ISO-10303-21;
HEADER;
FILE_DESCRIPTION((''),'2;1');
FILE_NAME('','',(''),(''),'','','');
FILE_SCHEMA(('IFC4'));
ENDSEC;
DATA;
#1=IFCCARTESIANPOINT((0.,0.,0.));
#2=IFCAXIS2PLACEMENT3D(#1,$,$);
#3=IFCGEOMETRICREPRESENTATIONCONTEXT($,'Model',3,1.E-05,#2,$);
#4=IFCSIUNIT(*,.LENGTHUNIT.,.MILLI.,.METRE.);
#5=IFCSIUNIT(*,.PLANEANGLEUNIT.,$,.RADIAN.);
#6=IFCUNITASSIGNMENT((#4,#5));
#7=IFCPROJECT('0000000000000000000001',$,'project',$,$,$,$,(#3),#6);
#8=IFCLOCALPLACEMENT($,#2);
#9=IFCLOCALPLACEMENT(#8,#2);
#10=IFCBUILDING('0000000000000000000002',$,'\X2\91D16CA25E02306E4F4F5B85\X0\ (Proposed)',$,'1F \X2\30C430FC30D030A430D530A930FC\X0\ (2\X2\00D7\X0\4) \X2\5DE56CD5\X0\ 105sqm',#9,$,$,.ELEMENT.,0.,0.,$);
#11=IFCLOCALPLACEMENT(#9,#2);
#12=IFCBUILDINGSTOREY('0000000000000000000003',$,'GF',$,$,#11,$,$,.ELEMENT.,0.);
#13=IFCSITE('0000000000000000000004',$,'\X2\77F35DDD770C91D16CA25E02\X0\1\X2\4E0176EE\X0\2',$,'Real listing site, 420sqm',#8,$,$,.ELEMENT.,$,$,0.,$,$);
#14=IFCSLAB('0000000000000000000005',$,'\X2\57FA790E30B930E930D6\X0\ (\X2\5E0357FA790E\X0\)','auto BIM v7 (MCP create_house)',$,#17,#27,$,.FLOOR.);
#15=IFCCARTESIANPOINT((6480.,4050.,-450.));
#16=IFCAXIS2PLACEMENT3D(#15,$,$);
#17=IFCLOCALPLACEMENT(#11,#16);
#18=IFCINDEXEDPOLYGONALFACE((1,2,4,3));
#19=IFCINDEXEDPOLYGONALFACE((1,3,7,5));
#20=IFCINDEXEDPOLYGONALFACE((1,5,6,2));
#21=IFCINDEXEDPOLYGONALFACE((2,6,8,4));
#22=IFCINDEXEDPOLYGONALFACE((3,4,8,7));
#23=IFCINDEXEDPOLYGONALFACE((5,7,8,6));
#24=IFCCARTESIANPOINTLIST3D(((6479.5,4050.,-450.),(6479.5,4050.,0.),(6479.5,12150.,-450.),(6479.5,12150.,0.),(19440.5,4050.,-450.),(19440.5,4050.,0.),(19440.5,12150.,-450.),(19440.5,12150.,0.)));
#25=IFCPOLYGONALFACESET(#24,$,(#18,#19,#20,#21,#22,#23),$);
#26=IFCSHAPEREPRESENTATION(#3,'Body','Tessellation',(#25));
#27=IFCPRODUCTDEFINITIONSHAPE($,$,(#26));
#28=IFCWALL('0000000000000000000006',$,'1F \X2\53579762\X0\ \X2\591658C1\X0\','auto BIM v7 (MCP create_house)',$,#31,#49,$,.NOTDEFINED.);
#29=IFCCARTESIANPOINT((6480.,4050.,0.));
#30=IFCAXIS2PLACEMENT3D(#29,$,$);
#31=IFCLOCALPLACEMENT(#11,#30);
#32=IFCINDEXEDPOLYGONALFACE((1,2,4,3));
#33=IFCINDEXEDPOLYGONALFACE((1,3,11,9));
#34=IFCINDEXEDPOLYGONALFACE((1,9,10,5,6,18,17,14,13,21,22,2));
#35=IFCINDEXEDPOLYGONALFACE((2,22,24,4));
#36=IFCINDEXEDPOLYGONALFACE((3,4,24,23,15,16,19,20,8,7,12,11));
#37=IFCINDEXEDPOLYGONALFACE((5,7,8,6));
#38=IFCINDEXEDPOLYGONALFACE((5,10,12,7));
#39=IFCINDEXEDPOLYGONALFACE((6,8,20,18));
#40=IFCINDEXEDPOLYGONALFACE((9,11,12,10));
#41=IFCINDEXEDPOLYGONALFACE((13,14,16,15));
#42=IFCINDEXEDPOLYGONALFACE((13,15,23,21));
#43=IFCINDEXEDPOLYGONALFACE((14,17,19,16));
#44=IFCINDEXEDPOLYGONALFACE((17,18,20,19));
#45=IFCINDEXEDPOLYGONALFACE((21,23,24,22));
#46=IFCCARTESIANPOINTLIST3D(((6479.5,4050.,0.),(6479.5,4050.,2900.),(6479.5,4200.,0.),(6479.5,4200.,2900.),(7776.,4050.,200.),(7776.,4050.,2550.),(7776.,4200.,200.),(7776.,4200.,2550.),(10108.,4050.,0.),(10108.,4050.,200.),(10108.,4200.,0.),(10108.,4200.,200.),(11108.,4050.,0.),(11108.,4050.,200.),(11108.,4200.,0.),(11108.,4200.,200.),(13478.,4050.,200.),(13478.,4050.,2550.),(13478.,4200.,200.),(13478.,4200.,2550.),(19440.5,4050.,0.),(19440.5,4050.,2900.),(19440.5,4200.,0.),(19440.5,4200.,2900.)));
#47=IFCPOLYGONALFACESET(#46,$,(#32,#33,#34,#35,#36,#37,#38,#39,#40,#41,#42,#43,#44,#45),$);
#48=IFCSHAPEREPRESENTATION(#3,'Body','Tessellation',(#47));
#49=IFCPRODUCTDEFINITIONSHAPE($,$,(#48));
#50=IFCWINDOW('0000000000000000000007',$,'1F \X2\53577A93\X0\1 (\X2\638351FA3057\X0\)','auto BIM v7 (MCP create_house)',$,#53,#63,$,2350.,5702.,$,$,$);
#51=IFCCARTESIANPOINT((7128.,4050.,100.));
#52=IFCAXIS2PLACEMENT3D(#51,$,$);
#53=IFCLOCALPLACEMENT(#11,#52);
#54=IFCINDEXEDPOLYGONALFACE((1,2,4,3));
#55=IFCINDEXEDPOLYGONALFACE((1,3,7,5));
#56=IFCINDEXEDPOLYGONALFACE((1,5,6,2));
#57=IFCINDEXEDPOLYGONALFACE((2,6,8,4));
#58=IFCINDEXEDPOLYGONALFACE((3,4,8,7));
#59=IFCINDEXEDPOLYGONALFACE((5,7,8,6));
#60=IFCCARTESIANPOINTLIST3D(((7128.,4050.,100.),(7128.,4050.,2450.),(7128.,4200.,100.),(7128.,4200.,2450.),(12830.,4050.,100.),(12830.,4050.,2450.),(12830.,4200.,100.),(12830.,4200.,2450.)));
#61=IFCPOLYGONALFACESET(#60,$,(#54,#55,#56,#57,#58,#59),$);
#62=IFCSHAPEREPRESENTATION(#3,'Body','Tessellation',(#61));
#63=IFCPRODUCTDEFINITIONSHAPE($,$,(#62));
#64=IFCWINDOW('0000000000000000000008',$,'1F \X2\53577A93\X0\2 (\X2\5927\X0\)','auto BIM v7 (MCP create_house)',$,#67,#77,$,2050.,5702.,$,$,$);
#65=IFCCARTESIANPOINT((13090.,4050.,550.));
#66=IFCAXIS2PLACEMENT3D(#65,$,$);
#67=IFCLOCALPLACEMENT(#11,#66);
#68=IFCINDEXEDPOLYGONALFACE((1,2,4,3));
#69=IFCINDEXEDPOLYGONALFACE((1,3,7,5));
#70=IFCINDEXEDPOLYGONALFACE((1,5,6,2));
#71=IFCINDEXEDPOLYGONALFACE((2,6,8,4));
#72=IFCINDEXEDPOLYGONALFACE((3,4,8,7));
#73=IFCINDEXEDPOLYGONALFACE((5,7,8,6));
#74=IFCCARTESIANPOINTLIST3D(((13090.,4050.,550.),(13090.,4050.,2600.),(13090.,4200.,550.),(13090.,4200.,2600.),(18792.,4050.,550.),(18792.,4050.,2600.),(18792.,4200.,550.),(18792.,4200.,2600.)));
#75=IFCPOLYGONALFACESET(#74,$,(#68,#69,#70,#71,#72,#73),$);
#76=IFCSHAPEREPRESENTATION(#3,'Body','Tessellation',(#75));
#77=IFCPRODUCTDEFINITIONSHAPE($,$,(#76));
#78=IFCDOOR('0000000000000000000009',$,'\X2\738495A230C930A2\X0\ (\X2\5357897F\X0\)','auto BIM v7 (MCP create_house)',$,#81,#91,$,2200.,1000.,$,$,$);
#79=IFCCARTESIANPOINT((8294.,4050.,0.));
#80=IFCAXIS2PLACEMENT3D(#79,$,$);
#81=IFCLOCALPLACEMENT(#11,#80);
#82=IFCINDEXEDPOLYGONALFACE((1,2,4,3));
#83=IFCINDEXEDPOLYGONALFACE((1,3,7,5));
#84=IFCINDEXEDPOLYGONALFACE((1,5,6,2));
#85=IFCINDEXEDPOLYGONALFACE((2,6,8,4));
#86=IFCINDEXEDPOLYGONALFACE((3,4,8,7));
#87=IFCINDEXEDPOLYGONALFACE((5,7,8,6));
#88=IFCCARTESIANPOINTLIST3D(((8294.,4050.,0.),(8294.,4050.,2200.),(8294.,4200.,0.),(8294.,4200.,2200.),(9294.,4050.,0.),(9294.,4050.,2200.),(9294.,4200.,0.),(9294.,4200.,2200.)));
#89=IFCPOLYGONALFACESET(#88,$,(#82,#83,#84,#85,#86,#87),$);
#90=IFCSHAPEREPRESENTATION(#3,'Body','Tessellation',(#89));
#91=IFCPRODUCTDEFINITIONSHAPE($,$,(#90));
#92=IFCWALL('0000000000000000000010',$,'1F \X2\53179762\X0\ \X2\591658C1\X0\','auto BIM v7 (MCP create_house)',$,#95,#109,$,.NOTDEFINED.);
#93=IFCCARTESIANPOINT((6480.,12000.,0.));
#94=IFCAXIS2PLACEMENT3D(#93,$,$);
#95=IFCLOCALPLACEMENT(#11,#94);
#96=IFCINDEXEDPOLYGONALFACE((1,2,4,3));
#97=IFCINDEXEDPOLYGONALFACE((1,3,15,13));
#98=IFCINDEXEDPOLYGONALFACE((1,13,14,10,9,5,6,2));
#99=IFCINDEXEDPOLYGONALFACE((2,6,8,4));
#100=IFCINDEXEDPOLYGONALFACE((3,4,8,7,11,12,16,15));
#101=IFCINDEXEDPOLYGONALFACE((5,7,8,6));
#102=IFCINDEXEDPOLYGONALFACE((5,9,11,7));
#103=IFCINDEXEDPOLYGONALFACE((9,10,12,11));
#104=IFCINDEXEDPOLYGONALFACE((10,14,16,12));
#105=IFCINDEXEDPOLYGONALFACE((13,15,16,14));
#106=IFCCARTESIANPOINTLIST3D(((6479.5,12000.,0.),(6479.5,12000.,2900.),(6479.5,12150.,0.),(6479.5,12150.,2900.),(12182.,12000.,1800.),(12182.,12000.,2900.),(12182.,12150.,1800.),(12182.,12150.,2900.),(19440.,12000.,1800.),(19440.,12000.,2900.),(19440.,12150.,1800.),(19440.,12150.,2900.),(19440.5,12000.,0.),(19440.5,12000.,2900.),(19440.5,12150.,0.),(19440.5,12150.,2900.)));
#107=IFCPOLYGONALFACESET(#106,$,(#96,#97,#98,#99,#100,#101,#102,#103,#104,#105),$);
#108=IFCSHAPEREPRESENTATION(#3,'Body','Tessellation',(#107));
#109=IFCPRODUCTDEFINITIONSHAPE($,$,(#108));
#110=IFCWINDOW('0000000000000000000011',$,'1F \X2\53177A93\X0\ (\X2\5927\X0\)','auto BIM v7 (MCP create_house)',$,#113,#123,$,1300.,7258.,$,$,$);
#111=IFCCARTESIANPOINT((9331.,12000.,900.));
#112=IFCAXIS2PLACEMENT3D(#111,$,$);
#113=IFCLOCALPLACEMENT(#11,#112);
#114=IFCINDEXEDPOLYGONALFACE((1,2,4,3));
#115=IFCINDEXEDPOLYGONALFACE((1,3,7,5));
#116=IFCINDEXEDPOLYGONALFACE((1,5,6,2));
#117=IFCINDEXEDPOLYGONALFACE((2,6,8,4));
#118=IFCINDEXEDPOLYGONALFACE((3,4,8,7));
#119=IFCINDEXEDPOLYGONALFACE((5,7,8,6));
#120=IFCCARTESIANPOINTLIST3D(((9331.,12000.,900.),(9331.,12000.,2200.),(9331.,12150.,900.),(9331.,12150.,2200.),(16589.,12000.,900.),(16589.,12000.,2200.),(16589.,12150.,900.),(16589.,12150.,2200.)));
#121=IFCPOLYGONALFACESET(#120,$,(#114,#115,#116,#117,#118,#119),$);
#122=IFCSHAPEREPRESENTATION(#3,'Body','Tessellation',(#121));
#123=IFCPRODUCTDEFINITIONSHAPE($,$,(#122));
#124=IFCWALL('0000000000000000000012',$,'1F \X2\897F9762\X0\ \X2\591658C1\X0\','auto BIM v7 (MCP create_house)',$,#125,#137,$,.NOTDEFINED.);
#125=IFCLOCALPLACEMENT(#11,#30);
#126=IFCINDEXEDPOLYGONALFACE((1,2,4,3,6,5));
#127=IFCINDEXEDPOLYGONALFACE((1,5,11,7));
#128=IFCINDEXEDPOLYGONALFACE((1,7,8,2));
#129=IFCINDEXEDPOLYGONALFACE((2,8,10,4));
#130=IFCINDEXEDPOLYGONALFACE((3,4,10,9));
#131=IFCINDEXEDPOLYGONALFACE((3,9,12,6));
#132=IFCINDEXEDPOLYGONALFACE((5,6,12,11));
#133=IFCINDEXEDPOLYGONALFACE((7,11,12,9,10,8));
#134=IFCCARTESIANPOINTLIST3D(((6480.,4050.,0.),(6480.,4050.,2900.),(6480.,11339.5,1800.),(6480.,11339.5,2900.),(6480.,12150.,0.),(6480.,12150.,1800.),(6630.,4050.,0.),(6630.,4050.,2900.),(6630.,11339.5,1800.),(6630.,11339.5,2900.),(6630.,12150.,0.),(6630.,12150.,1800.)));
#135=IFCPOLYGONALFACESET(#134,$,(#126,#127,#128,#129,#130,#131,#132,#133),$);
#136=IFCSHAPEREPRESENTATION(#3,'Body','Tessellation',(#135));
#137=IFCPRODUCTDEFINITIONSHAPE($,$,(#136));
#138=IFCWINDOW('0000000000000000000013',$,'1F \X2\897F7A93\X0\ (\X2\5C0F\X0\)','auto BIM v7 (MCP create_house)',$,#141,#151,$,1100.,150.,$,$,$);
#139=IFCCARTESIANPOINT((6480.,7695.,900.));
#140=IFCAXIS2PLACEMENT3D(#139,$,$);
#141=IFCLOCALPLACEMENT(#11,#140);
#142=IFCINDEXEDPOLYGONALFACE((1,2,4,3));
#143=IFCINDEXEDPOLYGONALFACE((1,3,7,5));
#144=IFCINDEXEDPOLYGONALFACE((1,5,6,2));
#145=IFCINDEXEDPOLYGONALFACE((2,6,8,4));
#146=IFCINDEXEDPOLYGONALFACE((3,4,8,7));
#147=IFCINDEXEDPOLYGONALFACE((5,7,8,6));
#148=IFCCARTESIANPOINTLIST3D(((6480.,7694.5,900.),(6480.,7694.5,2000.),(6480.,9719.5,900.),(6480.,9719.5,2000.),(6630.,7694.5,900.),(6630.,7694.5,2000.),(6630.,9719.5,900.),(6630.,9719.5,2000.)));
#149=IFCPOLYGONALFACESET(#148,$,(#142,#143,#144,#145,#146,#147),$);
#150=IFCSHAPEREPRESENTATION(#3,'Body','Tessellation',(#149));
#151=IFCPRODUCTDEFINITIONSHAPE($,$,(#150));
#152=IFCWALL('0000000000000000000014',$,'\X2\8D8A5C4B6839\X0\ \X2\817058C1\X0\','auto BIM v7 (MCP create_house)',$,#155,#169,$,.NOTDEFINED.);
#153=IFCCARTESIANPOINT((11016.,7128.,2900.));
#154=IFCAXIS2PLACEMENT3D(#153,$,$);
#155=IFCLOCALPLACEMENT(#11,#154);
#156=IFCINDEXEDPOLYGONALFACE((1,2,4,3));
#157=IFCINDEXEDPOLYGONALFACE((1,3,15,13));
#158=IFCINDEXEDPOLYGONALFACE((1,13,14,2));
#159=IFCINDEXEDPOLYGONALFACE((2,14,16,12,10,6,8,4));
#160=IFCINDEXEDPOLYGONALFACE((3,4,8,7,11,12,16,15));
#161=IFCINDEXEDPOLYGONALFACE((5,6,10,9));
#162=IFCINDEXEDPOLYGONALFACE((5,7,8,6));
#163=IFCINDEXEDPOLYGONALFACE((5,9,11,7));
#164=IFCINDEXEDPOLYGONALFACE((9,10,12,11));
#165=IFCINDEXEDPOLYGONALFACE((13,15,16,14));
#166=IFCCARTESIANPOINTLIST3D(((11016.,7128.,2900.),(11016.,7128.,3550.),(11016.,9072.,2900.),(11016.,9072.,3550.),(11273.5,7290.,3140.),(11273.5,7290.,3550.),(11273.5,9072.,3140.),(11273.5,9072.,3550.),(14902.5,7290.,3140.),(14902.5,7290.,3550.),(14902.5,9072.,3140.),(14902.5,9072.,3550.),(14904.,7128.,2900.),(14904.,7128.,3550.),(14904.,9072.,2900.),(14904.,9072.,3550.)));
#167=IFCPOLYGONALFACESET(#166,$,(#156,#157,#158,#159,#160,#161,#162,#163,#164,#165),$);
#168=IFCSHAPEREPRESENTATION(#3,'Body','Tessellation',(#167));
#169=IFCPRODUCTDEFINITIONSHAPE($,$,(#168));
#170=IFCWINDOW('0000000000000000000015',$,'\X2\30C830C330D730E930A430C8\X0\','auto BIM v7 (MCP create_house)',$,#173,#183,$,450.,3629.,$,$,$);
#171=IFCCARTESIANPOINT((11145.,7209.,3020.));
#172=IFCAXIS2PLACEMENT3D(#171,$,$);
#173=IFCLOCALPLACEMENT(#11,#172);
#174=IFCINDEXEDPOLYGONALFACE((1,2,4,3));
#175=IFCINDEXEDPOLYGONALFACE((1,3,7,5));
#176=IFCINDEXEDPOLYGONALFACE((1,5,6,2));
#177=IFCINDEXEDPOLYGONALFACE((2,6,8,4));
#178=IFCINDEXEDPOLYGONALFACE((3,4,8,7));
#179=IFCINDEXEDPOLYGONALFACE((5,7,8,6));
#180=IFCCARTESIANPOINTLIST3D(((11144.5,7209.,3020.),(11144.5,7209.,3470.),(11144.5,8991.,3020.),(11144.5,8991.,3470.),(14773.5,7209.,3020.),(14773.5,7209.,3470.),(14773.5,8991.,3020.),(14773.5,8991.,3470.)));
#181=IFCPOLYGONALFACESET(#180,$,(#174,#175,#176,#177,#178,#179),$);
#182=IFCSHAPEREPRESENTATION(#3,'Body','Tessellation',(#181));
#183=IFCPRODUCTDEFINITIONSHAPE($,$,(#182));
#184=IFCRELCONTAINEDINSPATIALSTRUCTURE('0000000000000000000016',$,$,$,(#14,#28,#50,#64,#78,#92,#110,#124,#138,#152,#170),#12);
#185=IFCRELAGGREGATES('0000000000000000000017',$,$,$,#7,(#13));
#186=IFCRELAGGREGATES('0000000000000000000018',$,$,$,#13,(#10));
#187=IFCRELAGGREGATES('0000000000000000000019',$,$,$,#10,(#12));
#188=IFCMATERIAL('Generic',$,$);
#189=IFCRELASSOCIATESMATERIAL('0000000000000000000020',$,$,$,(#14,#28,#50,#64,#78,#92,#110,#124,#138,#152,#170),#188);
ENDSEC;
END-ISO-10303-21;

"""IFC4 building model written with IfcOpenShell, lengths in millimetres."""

from ifc_helpers import new_model, si_unit, frame, frame_2d, origin, place, context, project, spatial, rectangle, extrude, material, element, fill, save


model = new_model("IFC4")

# Units and contexts
model_context = context("Model", 3, precision=1e-05, world=origin())
ifc_project = project(units=[si_unit("LENGTHUNIT", "METRE", prefix="MILLI"), si_unit("PLANEANGLEUNIT", "RADIAN")], contexts=[model_context])

# Site, building, storey
site_placement = place(None, origin())
site = spatial("IfcSite", under=ifc_project, at=site_placement, Name="石川県金沢市1丁目2", ObjectType="Real listing site, 420sqm", CompositionType="ELEMENT", RefElevation=0.0)
building_placement = place(site_placement, origin())
building = spatial("IfcBuilding", under=site, at=building_placement, Name="金沢市の住宅 (Proposed)", ObjectType="1F ツーバイフォー (2×4) 工法 105sqm", CompositionType="ELEMENT", ElevationOfRefHeight=0.0, ElevationOfTerrain=0.0)
storey_placement = place(building_placement, origin())
storey = spatial("IfcBuildingStorey", under=building, at=storey_placement, Name="GF", CompositionType="ELEMENT", Elevation=0.0)

# Slab
ifc_material = material(Name="Generic")
slab_1_placement = place(storey_placement, frame((6480.0, 4050.0, -450.0)))
element("IfcSlab", 1, at=slab_1_placement, inside=storey, material=ifc_material, Name="基礎スラブ (布基礎)", Description="auto BIM v7 (MCP create_house)", PredefinedType="FLOOR", context=model_context, shape_type="SweptSolid", body=[
    extrude(rectangle(XDim=12961.0, YDim=8100.0, at=frame_2d((6480.0, 4050.0))), frame((6480.0, 4050.0, -450.0)), (0.0, 0.0, 1.0), 450.0),
])

# Wall, openings, windows, door
wall_1_placement = place(storey_placement, frame((6480.0, 4050.0, 0.0)))
wall_1 = element("IfcWall", 2, at=wall_1_placement, inside=storey, material=ifc_material, Name="1F 南面 外壁", Description="auto BIM v7 (MCP create_house)", PredefinedType="NOTDEFINED", context=model_context, shape_type="SweptSolid", body=[
    extrude(rectangle(XDim=12961.0, YDim=150.0, at=frame_2d((6480.0, 75.0))), frame((6480.0, 4050.0, 0.0)), (0.0, 0.0, 1.0), 2900.0),
])
opening_1_placement = place(storey_placement, frame((7128.0, 4050.0, 100.0)))
opening_1 = element("IfcOpeningElement", 3, at=opening_1_placement, cuts=wall_1, PredefinedType="NOTDEFINED", context=model_context, shape_type="SweptSolid", body=[
    extrude(rectangle(XDim=5702.0, YDim=150.0, at=frame_2d((2851.0, 75.0))), frame((7128.0, 4050.0, 100.0)), (0.0, 0.0, 1.0), 2350.0),
])
opening_2_placement = place(storey_placement, frame((13090.0, 4050.0, 550.0)))
opening_2 = element("IfcOpeningElement", 4, at=opening_2_placement, cuts=wall_1, PredefinedType="NOTDEFINED", context=model_context, shape_type="SweptSolid", body=[
    extrude(rectangle(XDim=5702.0, YDim=150.0, at=frame_2d((2851.0, 75.0))), frame((13090.0, 4050.0, 550.0)), (0.0, 0.0, 1.0), 2050.0),
])
opening_3_placement = place(storey_placement, frame((8294.0, 4050.0, 0.0)))
opening_3 = element("IfcOpeningElement", 5, at=opening_3_placement, cuts=wall_1, PredefinedType="NOTDEFINED", context=model_context, shape_type="SweptSolid", body=[
    extrude(rectangle(XDim=1000.0, YDim=150.0, at=frame_2d((500.0, 75.0))), frame((8294.0, 4050.0, 0.0)), (0.0, 0.0, 1.0), 2200.0),
])
window_1_placement = place(storey_placement, frame((7128.0, 4050.0, 100.0)))
window_1 = element("IfcWindow", 6, at=window_1_placement, inside=storey, material=ifc_material, Name="1F 南窓1 (掃出し)", Description="auto BIM v7 (MCP create_house)", OverallHeight=2350.0, OverallWidth=5702.0, context=model_context, shape_type="SweptSolid", body=[
    extrude(rectangle(XDim=5702.0, YDim=150.0, at=frame_2d((2851.0, 75.0))), frame((7128.0, 4050.0, 100.0)), (0.0, 0.0, 1.0), 2350.0),
])
fill(opening_1, window_1)
window_2_placement = place(storey_placement, frame((13090.0, 4050.0, 550.0)))
window_2 = element("IfcWindow", 7, at=window_2_placement, inside=storey, material=ifc_material, Name="1F 南窓2 (大)", Description="auto BIM v7 (MCP create_house)", OverallHeight=2050.0, OverallWidth=5702.0, context=model_context, shape_type="SweptSolid", body=[
    extrude(rectangle(XDim=5702.0, YDim=150.0, at=frame_2d((2851.0, 75.0))), frame((13090.0, 4050.0, 550.0)), (0.0, 0.0, 1.0), 2050.0),
])
fill(opening_2, window_2)
door_placement = place(storey_placement, frame((8294.0, 4050.0, 0.0)))
door = element("IfcDoor", 8, at=door_placement, inside=storey, material=ifc_material, Name="玄関ドア (南西)", Description="auto BIM v7 (MCP create_house)", OverallHeight=2200.0, OverallWidth=1000.0, context=model_context, shape_type="SweptSolid", body=[
    extrude(rectangle(XDim=1000.0, YDim=150.0, at=frame_2d((500.0, 75.0))), frame((8294.0, 4050.0, 0.0)), (0.0, 0.0, 1.0), 2200.0),
])
fill(opening_3, door)

# Walls, openings, windows
wall_2_placement = place(storey_placement, frame((6480.0, 12000.0, 0.0)))
wall_2 = element("IfcWall", 9, at=wall_2_placement, inside=storey, material=ifc_material, Name="1F 北面 外壁", Description="auto BIM v7 (MCP create_house)", PredefinedType="NOTDEFINED", context=model_context, shape_type="SweptSolid", body=[
    extrude(rectangle(XDim=12961.0, YDim=150.0, at=frame_2d((6480.0, 75.0))), frame((6480.0, 12000.0, 0.0)), (0.0, 0.0, 1.0), 2900.0),
])
opening_4_placement = place(storey_placement, frame((9331.0, 12000.0, 900.0)))
opening_4 = element("IfcOpeningElement", 10, at=opening_4_placement, cuts=wall_2, PredefinedType="NOTDEFINED", context=model_context, shape_type="SweptSolid", body=[
    extrude(rectangle(XDim=7258.0, YDim=150.0, at=frame_2d((3629.0, 75.0))), frame((9331.0, 12000.0, 900.0)), (0.0, 0.0, 1.0), 1300.0),
])
window_3_placement = place(storey_placement, frame((9331.0, 12000.0, 900.0)))
window_3 = element("IfcWindow", 11, at=window_3_placement, inside=storey, material=ifc_material, Name="1F 北窓 (大)", Description="auto BIM v7 (MCP create_house)", OverallHeight=1300.0, OverallWidth=7258.0, context=model_context, shape_type="SweptSolid", body=[
    extrude(rectangle(XDim=7258.0, YDim=150.0, at=frame_2d((3629.0, 75.0))), frame((9331.0, 12000.0, 900.0)), (0.0, 0.0, 1.0), 1300.0),
])
fill(opening_4, window_3)
wall_3_placement = place(storey_placement, frame((6480.0, 4050.0, 0.0)))
wall_3 = element("IfcWall", 12, at=wall_3_placement, inside=storey, material=ifc_material, Name="1F 西面 外壁", Description="auto BIM v7 (MCP create_house)", PredefinedType="NOTDEFINED", context=model_context, shape_type="SweptSolid", body=[
    extrude(rectangle(XDim=150.0, YDim=8100.0, at=frame_2d((75.0, 4050.0))), frame((6480.0, 4050.0, 0.0)), (0.0, 0.0, 1.0), 2900.0),
])
opening_5_placement = place(storey_placement, frame((6480.0, 7695.0, 900.0)))
opening_5 = element("IfcOpeningElement", 13, at=opening_5_placement, cuts=wall_3, PredefinedType="NOTDEFINED", context=model_context, shape_type="SweptSolid", body=[
    extrude(rectangle(XDim=150.0, YDim=2025.0, at=frame_2d((75.0, 1012.0))), frame((6480.0, 7695.0, 900.0)), (0.0, 0.0, 1.0), 1100.0),
])
window_4_placement = place(storey_placement, frame((6480.0, 7695.0, 900.0)))
window_4 = element("IfcWindow", 14, at=window_4_placement, inside=storey, material=ifc_material, Name="1F 西窓 (小)", Description="auto BIM v7 (MCP create_house)", OverallHeight=1100.0, OverallWidth=150.0, context=model_context, shape_type="SweptSolid", body=[
    extrude(rectangle(XDim=150.0, YDim=2025.0, at=frame_2d((75.0, 1012.0))), frame((6480.0, 7695.0, 900.0)), (0.0, 0.0, 1.0), 1100.0),
])
fill(opening_5, window_4)

# Wall, opening, window
wall_4_placement = place(storey_placement, frame((11016.0, 7128.0, 2900.0)))
wall_4 = element("IfcWall", 15, at=wall_4_placement, inside=storey, material=ifc_material, Name="越屋根 腰壁", Description="auto BIM v7 (MCP create_house)", PredefinedType="NOTDEFINED", context=model_context, shape_type="SweptSolid", body=[
    extrude(rectangle(XDim=3888.0, YDim=1944.0, at=frame_2d((1944.0, 972.0))), frame((11016.0, 7128.0, 2900.0)), (0.0, 0.0, 1.0), 650.0),
])
opening_6_placement = place(storey_placement, frame((11145.0, 7209.0, 3020.0)))
opening_6 = element("IfcOpeningElement", 16, at=opening_6_placement, cuts=wall_4, PredefinedType="NOTDEFINED", context=model_context, shape_type="SweptSolid", body=[
    extrude(rectangle(XDim=3629.0, YDim=1782.0, at=frame_2d((1814.0, 891.0))), frame((11145.0, 7209.0, 3020.0)), (0.0, 0.0, 1.0), 450.0),
])
window_5_placement = place(storey_placement, frame((11145.0, 7209.0, 3020.0)))
window_5 = element("IfcWindow", 17, at=window_5_placement, inside=storey, material=ifc_material, Name="トップライト", Description="auto BIM v7 (MCP create_house)", OverallHeight=450.0, OverallWidth=3629.0, context=model_context, shape_type="SweptSolid", body=[
    extrude(rectangle(XDim=3629.0, YDim=1782.0, at=frame_2d((1814.0, 891.0))), frame((11145.0, 7209.0, 3020.0)), (0.0, 0.0, 1.0), 450.0),
])
fill(opening_6, window_5)

save(model, "model.ifc")
